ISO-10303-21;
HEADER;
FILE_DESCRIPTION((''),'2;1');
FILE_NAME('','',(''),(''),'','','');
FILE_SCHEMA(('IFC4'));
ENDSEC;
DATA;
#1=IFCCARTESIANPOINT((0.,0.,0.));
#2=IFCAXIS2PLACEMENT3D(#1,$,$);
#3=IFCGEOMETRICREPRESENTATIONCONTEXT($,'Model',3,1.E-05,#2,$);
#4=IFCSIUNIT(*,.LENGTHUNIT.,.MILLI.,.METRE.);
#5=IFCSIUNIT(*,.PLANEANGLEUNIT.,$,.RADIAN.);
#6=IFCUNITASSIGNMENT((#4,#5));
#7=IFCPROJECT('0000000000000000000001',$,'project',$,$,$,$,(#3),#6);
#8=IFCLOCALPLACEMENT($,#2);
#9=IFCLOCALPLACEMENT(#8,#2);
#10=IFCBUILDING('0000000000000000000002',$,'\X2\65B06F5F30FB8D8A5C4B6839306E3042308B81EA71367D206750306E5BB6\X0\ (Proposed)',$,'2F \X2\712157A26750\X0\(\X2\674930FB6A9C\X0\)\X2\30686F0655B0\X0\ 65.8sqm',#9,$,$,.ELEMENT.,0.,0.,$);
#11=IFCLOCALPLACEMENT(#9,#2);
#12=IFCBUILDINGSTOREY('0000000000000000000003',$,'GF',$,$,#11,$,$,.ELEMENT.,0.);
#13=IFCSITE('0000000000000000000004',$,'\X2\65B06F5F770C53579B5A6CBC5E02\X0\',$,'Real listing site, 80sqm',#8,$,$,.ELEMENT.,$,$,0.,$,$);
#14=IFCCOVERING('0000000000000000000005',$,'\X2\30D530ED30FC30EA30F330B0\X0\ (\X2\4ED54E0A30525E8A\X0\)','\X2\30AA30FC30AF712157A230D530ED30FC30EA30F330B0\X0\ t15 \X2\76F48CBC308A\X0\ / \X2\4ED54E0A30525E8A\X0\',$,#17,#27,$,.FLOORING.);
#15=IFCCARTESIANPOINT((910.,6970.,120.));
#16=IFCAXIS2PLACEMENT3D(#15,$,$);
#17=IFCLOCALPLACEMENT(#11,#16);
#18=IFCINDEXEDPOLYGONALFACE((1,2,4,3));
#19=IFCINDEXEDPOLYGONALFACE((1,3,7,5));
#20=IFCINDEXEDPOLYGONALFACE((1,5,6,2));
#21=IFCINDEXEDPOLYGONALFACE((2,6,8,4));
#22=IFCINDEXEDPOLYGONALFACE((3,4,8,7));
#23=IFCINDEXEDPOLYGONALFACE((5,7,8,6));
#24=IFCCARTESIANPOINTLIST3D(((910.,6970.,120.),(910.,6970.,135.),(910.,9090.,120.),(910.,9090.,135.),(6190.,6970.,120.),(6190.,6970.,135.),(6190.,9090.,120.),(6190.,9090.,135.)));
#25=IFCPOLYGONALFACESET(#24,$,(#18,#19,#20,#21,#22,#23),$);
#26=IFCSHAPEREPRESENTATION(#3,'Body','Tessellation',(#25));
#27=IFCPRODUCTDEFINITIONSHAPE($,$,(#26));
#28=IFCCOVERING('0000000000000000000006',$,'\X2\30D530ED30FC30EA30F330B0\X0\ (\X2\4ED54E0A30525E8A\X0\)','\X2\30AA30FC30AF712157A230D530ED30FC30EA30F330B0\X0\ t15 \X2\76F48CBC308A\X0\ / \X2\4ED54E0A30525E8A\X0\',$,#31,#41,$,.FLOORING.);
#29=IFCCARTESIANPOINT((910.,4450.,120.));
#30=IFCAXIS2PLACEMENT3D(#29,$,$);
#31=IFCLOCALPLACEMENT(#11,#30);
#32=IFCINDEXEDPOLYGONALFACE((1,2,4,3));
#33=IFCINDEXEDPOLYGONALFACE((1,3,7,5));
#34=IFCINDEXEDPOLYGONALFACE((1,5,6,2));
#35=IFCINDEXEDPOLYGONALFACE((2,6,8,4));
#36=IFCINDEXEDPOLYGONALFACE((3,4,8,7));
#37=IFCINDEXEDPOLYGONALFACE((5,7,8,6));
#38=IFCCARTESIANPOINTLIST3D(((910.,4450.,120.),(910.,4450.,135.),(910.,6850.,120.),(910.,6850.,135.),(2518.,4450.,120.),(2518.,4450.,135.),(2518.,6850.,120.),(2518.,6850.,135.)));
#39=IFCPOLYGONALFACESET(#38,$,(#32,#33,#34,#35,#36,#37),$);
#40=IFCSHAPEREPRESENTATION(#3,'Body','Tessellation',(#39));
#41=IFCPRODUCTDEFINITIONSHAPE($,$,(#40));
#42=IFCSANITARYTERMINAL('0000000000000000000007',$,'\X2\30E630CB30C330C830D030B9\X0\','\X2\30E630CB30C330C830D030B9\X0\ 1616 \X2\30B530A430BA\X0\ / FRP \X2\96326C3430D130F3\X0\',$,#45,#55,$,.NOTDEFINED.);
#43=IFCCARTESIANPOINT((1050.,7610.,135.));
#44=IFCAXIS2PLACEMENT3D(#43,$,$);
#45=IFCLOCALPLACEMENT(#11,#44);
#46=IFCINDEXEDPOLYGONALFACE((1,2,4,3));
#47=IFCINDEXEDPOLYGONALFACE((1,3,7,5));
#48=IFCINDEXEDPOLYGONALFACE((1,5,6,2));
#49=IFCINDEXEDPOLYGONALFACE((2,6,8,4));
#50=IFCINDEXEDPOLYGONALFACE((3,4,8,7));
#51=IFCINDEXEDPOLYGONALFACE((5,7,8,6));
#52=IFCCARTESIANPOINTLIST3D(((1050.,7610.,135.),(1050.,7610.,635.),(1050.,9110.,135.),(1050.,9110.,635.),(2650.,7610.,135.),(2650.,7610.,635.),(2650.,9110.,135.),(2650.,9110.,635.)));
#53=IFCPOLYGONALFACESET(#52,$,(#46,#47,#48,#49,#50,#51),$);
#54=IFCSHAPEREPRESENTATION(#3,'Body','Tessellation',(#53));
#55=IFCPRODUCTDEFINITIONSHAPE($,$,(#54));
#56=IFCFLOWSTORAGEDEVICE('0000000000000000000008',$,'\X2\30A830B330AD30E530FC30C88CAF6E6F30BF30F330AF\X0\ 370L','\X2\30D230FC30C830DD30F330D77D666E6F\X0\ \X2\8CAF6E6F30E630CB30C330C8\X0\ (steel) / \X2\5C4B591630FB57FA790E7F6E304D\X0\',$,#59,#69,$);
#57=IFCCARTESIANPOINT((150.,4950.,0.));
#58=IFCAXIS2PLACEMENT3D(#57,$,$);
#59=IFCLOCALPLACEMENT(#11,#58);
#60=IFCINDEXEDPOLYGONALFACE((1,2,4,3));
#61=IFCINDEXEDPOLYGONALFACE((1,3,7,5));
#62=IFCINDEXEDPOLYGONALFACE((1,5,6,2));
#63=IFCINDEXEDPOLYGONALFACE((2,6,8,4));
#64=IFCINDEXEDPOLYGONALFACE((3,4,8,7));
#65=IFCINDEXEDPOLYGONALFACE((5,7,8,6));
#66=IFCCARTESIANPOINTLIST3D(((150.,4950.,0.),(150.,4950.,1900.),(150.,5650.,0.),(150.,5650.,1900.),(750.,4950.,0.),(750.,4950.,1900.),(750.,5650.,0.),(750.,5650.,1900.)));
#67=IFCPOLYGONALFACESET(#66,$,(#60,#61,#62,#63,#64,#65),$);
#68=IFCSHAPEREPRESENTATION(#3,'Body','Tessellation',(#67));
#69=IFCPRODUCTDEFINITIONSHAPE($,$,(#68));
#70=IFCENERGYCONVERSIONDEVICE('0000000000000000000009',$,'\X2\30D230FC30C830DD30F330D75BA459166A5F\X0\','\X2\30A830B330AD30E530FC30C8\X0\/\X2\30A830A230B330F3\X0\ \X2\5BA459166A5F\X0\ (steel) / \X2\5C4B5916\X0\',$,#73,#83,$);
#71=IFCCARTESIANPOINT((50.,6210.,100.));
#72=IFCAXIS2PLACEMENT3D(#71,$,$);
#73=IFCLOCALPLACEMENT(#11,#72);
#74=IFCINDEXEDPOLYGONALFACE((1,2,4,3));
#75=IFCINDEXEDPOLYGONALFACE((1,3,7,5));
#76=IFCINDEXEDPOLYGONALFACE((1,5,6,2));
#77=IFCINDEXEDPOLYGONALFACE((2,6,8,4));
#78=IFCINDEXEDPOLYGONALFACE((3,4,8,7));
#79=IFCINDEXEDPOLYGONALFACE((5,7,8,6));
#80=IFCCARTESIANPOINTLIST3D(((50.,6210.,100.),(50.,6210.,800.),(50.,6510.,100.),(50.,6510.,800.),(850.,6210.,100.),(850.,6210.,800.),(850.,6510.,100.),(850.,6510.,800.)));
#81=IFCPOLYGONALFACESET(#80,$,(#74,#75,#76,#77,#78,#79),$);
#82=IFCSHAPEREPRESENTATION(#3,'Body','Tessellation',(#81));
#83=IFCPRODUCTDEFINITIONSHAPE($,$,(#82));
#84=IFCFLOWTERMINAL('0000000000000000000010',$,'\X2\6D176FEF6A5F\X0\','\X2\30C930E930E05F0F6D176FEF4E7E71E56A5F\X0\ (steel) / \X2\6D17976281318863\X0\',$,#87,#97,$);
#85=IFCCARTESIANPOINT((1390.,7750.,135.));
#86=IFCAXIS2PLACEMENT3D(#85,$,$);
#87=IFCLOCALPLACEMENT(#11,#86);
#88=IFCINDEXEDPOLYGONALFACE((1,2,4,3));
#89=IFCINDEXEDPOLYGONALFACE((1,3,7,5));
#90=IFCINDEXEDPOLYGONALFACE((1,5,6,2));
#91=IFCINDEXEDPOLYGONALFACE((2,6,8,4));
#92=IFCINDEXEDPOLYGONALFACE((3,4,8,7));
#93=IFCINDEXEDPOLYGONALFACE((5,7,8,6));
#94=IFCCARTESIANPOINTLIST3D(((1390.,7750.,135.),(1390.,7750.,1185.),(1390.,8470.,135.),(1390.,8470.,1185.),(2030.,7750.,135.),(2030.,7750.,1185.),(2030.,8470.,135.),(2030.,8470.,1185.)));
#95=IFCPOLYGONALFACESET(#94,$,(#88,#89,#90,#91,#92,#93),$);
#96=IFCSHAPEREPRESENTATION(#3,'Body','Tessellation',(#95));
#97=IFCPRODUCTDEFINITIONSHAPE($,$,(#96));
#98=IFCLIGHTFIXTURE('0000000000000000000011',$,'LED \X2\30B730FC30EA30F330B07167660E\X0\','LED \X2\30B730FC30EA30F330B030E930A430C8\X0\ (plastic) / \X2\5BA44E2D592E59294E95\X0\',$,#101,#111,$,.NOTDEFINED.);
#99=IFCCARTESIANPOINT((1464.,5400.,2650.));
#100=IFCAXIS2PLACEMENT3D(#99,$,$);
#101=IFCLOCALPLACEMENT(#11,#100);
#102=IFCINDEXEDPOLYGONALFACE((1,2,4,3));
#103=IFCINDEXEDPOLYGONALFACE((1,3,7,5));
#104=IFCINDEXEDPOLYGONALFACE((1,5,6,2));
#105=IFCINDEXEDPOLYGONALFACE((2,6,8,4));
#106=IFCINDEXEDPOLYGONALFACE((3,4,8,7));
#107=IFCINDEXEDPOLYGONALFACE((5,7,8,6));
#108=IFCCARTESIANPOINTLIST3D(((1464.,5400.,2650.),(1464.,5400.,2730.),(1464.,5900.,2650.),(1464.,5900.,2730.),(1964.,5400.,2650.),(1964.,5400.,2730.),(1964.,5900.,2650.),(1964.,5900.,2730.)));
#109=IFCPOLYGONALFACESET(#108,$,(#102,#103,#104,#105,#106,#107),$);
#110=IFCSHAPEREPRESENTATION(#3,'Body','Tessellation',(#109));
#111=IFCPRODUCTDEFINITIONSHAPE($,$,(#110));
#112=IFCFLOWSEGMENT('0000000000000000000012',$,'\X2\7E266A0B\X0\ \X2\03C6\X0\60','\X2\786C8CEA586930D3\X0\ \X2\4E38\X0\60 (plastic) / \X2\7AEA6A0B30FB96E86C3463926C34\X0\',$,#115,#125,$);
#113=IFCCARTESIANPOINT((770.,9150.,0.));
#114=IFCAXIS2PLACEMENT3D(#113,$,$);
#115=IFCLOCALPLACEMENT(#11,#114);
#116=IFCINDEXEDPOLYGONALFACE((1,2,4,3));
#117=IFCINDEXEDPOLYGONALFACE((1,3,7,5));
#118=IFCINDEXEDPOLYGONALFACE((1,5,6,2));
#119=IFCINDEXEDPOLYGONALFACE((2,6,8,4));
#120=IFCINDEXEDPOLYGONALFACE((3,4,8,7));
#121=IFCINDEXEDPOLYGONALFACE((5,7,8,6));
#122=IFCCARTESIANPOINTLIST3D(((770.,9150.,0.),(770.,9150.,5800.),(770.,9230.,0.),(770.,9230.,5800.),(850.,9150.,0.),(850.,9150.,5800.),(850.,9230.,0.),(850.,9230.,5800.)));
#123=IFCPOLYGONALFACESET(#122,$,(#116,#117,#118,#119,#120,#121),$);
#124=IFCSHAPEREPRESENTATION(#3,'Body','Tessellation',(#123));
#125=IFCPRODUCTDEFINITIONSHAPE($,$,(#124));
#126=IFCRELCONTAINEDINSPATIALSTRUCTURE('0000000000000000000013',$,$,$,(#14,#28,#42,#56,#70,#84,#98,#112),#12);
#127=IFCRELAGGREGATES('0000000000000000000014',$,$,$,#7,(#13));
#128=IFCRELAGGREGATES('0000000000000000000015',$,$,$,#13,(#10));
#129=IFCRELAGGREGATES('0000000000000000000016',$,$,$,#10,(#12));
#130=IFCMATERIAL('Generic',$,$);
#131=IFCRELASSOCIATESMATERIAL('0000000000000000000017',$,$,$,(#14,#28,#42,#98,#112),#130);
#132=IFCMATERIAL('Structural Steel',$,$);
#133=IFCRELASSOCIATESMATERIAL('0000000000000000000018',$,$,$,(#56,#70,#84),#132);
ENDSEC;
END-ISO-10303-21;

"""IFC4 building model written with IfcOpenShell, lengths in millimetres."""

from ifc_helpers import new_model, si_unit, frame, frame_2d, origin, place, context, project, spatial, rectangle, extrude, material, element, save


model = new_model("IFC4")

# Units and contexts
model_context = context("Model", 3, precision=1e-05, world=origin())
ifc_project = project(units=[si_unit("LENGTHUNIT", "METRE", prefix="MILLI"), si_unit("PLANEANGLEUNIT", "RADIAN")], contexts=[model_context])

# Site, building, storey
site_placement = place(None, origin())
site = spatial("IfcSite", under=ifc_project, at=site_placement, Name="新潟県南魚沼市", ObjectType="Real listing site, 80sqm", CompositionType="ELEMENT", RefElevation=0.0)
building_placement = place(site_placement, origin())
building = spatial("IfcBuilding", under=site, at=building_placement, Name="新潟・越屋根のある自然素材の家 (Proposed)", ObjectType="2F 無垢材(杉・檜)と漆喰 65.8sqm", CompositionType="ELEMENT", ElevationOfRefHeight=0.0, ElevationOfTerrain=0.0)
storey_placement = place(building_placement, origin())
storey = spatial("IfcBuildingStorey", under=building, at=storey_placement, Name="GF", CompositionType="ELEMENT", Elevation=0.0)

# Coverings
ifc_material_1 = material(Name="Generic")
covering_1_placement = place(storey_placement, frame((910.0, 6970.0, 120.0)))
element("IfcCovering", 1, at=covering_1_placement, inside=storey, material=ifc_material_1, Name="フローリング (仕上げ床)", Description="オーク無垢フローリング t15 直貼り / 仕上げ床", PredefinedType="FLOORING", context=model_context, shape_type="SweptSolid", body=[
    extrude(rectangle(XDim=5280.0, YDim=2120.0, at=frame_2d((2640.0, 1060.0))), frame((910.0, 6970.0, 120.0)), (0.0, 0.0, 1.0), 15.0),
])
covering_2_placement = place(storey_placement, frame((910.0, 4450.0, 120.0)))
element("IfcCovering", 2, at=covering_2_placement, inside=storey, material=ifc_material_1, Name="フローリング (仕上げ床)", Description="オーク無垢フローリング t15 直貼り / 仕上げ床", PredefinedType="FLOORING", context=model_context, shape_type="SweptSolid", body=[
    extrude(rectangle(XDim=1608.0, YDim=2400.0, at=frame_2d((804.0, 1200.0))), frame((910.0, 4450.0, 120.0)), (0.0, 0.0, 1.0), 15.0),
])

# Sanitary terminal
sanitary_terminal_placement = place(storey_placement, frame((1050.0, 7610.0, 135.0)))
element("IfcSanitaryTerminal", 3, at=sanitary_terminal_placement, inside=storey, material=ifc_material_1, Name="ユニットバス", Description="ユニットバス 1616 サイズ / FRP 防水パン", PredefinedType="NOTDEFINED", context=model_context, shape_type="SweptSolid", body=[
    extrude(rectangle(XDim=1600.0, YDim=1500.0, at=frame_2d((800.0, 750.0))), frame((1050.0, 7610.0, 135.0)), (0.0, 0.0, 1.0), 500.0),
])

# Flow storage device
ifc_material_2 = material(Name="Structural Steel")
flow_storage_device_placement = place(storey_placement, frame((150.0, 4950.0, 0.0)))
element("IfcFlowStorageDevice", 4, at=flow_storage_device_placement, inside=storey, material=ifc_material_2, Name="エコキュート貯湯タンク 370L", Description="ヒートポンプ給湯 貯湯ユニット (steel) / 屋外・基礎置き", context=model_context, shape_type="SweptSolid", body=[
    extrude(rectangle(XDim=600.0, YDim=700.0, at=frame_2d((300.0, 350.0))), frame((150.0, 4950.0, 0.0)), (0.0, 0.0, 1.0), 1900.0),
])

# Energy conversion device
energy_conversion_device_placement = place(storey_placement, frame((50.0, 6210.0, 100.0)))
element("IfcEnergyConversionDevice", 5, at=energy_conversion_device_placement, inside=storey, material=ifc_material_2, Name="ヒートポンプ室外機", Description="エコキュート/エアコン 室外機 (steel) / 屋外", context=model_context, shape_type="SweptSolid", body=[
    extrude(rectangle(XDim=800.0, YDim=300.0, at=frame_2d((400.0, 150.0))), frame((50.0, 6210.0, 100.0)), (0.0, 0.0, 1.0), 700.0),
])

# Flow terminal
flow_terminal_placement = place(storey_placement, frame((1390.0, 7750.0, 135.0)))
element("IfcFlowTerminal", 6, at=flow_terminal_placement, inside=storey, material=ifc_material_2, Name="洗濯機", Description="ドラム式洗濯乾燥機 (steel) / 洗面脱衣", context=model_context, shape_type="SweptSolid", body=[
    extrude(rectangle(XDim=640.0, YDim=720.0, at=frame_2d((320.0, 360.0))), frame((1390.0, 7750.0, 135.0)), (0.0, 0.0, 1.0), 1050.0),
])

# Light fixture
light_fixture_placement = place(storey_placement, frame((1464.0, 5400.0, 2650.0)))
element("IfcLightFixture", 7, at=light_fixture_placement, inside=storey, material=ifc_material_1, Name="LED シーリング照明", Description="LED シーリングライト (plastic) / 室中央天井", PredefinedType="NOTDEFINED", context=model_context, shape_type="SweptSolid", body=[
    extrude(rectangle(XDim=500.0, YDim=500.0, at=frame_2d((250.0, 250.0))), frame((1464.0, 5400.0, 2650.0)), (0.0, 0.0, 1.0), 80.0),
])

# Flow segment
flow_segment_placement = place(storey_placement, frame((770.0, 9150.0, 0.0)))
element("IfcFlowSegment", 8, at=flow_segment_placement, inside=storey, material=ifc_material_1, Name="縦樋 φ60", Description="硬質塩ビ 丸60 (plastic) / 竪樋・雨水排水", context=model_context, shape_type="SweptSolid", body=[
    extrude(rectangle(XDim=80.0, YDim=80.0, at=frame_2d((40.0, 40.0))), frame((770.0, 9150.0, 0.0)), (0.0, 0.0, 1.0), 5800.0),
])

save(model, "model.ifc")
